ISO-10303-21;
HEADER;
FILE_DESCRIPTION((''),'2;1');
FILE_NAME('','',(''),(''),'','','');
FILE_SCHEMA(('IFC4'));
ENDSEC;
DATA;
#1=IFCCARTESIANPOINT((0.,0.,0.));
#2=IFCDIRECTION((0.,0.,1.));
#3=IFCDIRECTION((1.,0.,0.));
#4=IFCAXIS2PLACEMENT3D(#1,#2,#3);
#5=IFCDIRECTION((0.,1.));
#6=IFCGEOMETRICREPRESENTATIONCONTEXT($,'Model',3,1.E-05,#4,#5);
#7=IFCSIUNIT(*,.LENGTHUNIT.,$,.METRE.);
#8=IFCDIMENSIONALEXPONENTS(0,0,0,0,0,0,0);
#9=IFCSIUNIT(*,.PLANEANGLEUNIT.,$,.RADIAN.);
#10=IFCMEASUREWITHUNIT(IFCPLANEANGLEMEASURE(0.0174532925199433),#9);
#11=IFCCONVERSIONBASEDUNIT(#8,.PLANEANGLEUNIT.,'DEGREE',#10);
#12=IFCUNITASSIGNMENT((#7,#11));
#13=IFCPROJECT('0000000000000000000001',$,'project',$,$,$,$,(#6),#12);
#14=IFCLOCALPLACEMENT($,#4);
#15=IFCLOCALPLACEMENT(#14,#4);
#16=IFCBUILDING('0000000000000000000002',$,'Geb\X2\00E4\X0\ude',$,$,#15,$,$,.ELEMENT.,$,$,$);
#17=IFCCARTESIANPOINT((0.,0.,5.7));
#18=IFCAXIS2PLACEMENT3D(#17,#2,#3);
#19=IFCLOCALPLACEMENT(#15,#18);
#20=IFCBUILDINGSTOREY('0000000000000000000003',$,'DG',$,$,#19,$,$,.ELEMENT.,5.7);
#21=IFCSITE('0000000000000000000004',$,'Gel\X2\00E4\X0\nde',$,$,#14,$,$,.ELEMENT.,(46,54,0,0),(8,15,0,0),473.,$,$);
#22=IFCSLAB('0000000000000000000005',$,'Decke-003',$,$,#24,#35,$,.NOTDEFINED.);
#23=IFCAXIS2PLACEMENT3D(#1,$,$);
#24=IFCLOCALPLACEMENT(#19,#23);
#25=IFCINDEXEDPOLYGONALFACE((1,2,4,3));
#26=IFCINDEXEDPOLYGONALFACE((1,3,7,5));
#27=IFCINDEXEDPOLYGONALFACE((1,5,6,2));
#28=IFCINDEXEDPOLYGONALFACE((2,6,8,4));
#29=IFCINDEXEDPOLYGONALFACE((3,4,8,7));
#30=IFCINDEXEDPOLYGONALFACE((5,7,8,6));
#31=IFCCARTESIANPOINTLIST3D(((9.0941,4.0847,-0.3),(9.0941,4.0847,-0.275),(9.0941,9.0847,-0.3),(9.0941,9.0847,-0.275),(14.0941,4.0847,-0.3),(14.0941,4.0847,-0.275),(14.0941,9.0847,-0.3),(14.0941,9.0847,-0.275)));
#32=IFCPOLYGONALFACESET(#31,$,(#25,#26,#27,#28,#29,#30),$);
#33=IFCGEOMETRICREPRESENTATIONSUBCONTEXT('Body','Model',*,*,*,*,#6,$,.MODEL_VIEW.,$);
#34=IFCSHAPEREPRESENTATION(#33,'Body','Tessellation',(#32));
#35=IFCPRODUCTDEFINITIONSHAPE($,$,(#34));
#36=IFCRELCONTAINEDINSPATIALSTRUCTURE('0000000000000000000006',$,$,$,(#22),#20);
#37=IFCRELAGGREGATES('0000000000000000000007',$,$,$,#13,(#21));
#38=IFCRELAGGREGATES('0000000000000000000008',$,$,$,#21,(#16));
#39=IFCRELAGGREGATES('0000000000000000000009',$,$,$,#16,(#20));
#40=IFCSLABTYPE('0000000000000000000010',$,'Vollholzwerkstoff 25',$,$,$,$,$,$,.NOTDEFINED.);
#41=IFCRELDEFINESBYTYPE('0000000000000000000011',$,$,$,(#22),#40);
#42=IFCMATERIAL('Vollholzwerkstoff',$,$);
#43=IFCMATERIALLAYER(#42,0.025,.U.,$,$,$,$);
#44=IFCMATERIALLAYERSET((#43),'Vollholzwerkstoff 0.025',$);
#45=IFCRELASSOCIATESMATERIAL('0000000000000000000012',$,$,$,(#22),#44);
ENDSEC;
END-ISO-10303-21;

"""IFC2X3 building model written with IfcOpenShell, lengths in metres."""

from ifc_helpers import new_model, entity, si_unit, converted_unit, direction, frame, origin_with_axes, place, context, subcontext, project, spatial, polyline, outline, extrude, material, layer, layer_set, layer_usage, type_object, element, save


model = new_model("IFC2X3")

# Units and contexts
model_context = context("Model", 3, precision=1e-05, world=origin_with_axes(), true_north=direction((0.0, 1.0)))
body_context = subcontext(model_context, "Body", "Model", "MODEL_VIEW")
ifc_project = project(units=[si_unit("LENGTHUNIT", "METRE"), converted_unit("PLANEANGLEUNIT", "DEGREE", entity("IfcPlaneAngleMeasure", 0.0174532925199433), si_unit("PLANEANGLEUNIT", "RADIAN"), dimensions=[0, 0, 0, 0, 0, 0, 0])], contexts=[model_context])

# Site, building, storey
site_placement = place(None, origin_with_axes())
site = spatial("IfcSite", under=ifc_project, at=site_placement, Name="Gelände", CompositionType="ELEMENT", RefLatitude=(46, 54, 0, 0), RefLongitude=(8, 15, 0, 0), RefElevation=473.0)
building_placement = place(site_placement, origin_with_axes())
building = spatial("IfcBuilding", under=site, at=building_placement, Name="Gebäude", CompositionType="ELEMENT")
storey_placement = place(building_placement, frame((0.0, 0.0, 5.7), z_axis=(0.0, 0.0, 1.0), x_axis=(1.0, 0.0, 0.0)))
storey = spatial("IfcBuildingStorey", under=building, at=storey_placement, Name="DG", CompositionType="ELEMENT", Elevation=5.7)

# Slab
ifc_material = material(Name="Vollholzwerkstoff")
ifc_layer = layer(ifc_material, 0.025, ventilated="UNKNOWN")
ifc_layer_set = layer_set([ifc_layer], Name="Vollholzwerkstoff 0.025")
ifc_layer_usage = layer_usage(ifc_layer_set, "AXIS3", "NEGATIVE", 0.025)
slab_type = type_object("IfcSlabType", Name="Vollholzwerkstoff 25", PredefinedType="NOTDEFINED")
slab_placement = place(storey_placement, frame((9.0941, 4.0847, -0.275), z_axis=(0.0, 0.0, 1.0), x_axis=(1.0, 0.0, 0.0)))
element("IfcSlab", 1, at=slab_placement, inside=storey, type_object=slab_type, material=ifc_layer_usage, Name="Decke-003", PredefinedType="NOTDEFINED", context=body_context, shape_type="SweptSolid", body=[
    extrude(outline(polyline([(0.0, 0.0), (5.0, 0.0), (5.0, 5.0), (0.0, 5.0), (0.0, 0.0)])), frame((0.0, 0.0, -0.025), z_axis=(0.0, 0.0, 1.0), x_axis=(1.0, 0.0, 0.0)), (0.0, 0.0, 1.0), 0.025),
])

save(model, "model.ifc")
